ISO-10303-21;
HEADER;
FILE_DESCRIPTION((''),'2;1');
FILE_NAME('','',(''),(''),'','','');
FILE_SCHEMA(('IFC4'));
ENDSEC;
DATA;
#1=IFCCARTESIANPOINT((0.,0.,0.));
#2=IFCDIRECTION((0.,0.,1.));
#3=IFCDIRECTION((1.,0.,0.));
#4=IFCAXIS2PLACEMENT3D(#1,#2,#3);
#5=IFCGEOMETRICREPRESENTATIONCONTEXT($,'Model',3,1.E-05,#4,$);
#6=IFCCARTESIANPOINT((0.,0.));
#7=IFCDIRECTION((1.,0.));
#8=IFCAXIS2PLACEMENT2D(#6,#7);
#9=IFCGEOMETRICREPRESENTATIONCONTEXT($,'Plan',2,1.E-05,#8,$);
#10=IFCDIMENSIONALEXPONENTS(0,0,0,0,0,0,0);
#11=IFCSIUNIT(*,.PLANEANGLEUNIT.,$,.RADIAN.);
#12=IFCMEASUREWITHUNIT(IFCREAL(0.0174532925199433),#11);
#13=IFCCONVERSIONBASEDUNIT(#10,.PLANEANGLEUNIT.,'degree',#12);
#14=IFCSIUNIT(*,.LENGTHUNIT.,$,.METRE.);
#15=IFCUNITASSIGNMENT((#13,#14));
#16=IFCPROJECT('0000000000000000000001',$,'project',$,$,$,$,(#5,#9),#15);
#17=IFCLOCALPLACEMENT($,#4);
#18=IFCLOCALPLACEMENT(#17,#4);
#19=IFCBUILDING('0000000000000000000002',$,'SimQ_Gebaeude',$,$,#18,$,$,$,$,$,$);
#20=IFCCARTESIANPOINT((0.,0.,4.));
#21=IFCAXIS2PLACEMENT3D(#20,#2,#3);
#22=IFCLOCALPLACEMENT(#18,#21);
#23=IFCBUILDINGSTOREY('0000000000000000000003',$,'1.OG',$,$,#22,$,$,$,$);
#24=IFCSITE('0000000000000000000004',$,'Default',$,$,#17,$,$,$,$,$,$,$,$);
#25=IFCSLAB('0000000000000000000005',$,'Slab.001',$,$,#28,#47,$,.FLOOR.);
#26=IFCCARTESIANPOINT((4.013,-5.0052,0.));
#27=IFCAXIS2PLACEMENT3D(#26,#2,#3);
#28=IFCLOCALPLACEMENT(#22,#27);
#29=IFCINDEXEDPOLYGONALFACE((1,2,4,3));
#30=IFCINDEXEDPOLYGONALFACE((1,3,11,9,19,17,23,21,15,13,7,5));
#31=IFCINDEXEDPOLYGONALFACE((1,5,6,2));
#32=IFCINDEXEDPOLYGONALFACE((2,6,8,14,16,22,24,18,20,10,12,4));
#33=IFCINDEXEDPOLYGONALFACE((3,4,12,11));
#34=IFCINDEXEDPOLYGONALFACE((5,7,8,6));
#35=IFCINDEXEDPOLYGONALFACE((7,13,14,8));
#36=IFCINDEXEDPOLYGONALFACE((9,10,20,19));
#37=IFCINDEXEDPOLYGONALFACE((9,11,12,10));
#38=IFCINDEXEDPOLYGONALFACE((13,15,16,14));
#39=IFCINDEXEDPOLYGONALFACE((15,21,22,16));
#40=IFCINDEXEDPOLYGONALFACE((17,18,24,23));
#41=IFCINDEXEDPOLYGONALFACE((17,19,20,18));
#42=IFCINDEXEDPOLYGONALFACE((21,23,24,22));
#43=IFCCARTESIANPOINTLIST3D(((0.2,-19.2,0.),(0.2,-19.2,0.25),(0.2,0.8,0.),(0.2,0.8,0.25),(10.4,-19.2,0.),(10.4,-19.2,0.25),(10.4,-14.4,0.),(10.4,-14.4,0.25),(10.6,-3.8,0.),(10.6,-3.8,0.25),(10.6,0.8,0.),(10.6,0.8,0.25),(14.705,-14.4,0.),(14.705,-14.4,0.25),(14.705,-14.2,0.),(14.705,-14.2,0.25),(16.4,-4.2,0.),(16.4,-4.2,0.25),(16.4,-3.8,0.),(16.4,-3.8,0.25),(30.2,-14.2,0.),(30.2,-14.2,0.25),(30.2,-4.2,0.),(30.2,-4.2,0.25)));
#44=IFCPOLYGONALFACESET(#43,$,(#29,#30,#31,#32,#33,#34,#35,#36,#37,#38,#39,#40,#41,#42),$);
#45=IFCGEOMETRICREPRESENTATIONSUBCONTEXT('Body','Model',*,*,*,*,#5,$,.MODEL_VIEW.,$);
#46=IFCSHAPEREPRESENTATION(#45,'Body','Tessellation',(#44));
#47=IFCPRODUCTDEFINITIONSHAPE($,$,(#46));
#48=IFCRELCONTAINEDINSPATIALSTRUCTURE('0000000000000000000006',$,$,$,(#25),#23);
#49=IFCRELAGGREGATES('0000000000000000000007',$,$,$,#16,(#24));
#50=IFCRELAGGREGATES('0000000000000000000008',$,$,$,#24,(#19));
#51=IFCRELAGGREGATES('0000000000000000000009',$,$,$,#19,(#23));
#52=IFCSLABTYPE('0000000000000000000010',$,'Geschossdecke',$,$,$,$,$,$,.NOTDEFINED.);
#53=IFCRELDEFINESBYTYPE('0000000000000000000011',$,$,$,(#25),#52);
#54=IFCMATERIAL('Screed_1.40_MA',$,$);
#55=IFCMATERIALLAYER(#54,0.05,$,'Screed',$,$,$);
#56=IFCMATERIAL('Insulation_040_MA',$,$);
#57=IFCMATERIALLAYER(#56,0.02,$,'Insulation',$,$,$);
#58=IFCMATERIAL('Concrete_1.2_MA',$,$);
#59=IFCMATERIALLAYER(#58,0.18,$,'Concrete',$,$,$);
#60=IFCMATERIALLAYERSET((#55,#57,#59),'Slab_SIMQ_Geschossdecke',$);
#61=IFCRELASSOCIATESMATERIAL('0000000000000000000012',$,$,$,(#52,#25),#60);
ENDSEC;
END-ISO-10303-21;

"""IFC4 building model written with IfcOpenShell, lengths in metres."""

from ifc_helpers import new_model, entity, si_unit, converted_unit, frame, origin_with_axes, origin_2d_with_axis, place, context, subcontext, project, spatial, line, indexed_curve, outline, extrude, material, layer, layer_set, layer_usage, type_object, element, save


model = new_model("IFC4")

# Units and contexts
model_context = context("Model", 3, precision=1e-05, world=origin_with_axes())
plan_context = context("Plan", 2, precision=1e-05, world=origin_2d_with_axis())
body_context = subcontext(model_context, "Body", "Model", "MODEL_VIEW")
ifc_project = project(units=[converted_unit("PLANEANGLEUNIT", "degree", entity("IfcReal", 0.0174532925199433), si_unit("PLANEANGLEUNIT", "RADIAN"), dimensions=[0, 0, 0, 0, 0, 0, 0]), si_unit("LENGTHUNIT", "METRE")], contexts=[model_context, plan_context])

# Site, building, storey
site_placement = place(None, origin_with_axes())
site = spatial("IfcSite", under=ifc_project, at=site_placement, Name="Default")
building_placement = place(site_placement, origin_with_axes())
building = spatial("IfcBuilding", under=site, at=building_placement, Name="SimQ_Gebaeude")
storey_placement = place(building_placement, frame((0.0, 0.0, 4.0), z_axis=(0.0, 0.0, 1.0), x_axis=(1.0, 0.0, 0.0)))
storey = spatial("IfcBuildingStorey", under=building, at=storey_placement, Name="1.OG")

# Slab
ifc_material_1 = material(Name="Screed_1.40_MA")
ifc_layer_1 = layer(ifc_material_1, 0.05, Name="Screed")
ifc_material_2 = material(Name="Insulation_040_MA")
ifc_layer_2 = layer(ifc_material_2, 0.02, Name="Insulation")
ifc_material_3 = material(Name="Concrete_1.2_MA")
ifc_layer_3 = layer(ifc_material_3, 0.18, Name="Concrete")
ifc_layer_set_1 = layer_set([ifc_layer_1, ifc_layer_2, ifc_layer_3], Name="Slab_SIMQ_Geschossdecke")
ifc_layer_usage_1 = layer_usage(ifc_layer_set_1, "AXIS3", "POSITIVE", 0.0)
slab_type = type_object("IfcSlabType", Name="Geschossdecke", PredefinedType="NOTDEFINED", material=ifc_layer_set_1)
slab_placement = place(storey_placement, frame((4.013, -5.0052, 0.0), z_axis=(0.0, 0.0, 1.0), x_axis=(1.0, 0.0, 0.0)))
element("IfcSlab", 1, at=slab_placement, inside=storey, type_object=slab_type, material=ifc_layer_usage_1, Name="Slab.001", PredefinedType="FLOOR", context=body_context, shape_type="SweptSolid", body=[
    extrude(outline(indexed_curve([(10.4, -19.2), (10.4, -14.4), (30.2, -14.2), (30.2, -4.2), (10.6, -3.8), (10.6, 0.8), (0.2, 0.8), (0.2, -19.2), (16.4, -3.8), (16.4, -4.2), (14.705, -14.4), (14.705, -14.2)], segments=[line(10, 4), line(4, 3), line(3, 12), line(12, 11), line(11, 2), line(2, 1), line(1, 8), line(8, 7), line(7, 6), line(6, 5), line(5, 9), line(9, 10)], self_intersect=False)), None, (0.0, 0.0, 1.0), 0.25),
])

save(model, "model.ifc")
